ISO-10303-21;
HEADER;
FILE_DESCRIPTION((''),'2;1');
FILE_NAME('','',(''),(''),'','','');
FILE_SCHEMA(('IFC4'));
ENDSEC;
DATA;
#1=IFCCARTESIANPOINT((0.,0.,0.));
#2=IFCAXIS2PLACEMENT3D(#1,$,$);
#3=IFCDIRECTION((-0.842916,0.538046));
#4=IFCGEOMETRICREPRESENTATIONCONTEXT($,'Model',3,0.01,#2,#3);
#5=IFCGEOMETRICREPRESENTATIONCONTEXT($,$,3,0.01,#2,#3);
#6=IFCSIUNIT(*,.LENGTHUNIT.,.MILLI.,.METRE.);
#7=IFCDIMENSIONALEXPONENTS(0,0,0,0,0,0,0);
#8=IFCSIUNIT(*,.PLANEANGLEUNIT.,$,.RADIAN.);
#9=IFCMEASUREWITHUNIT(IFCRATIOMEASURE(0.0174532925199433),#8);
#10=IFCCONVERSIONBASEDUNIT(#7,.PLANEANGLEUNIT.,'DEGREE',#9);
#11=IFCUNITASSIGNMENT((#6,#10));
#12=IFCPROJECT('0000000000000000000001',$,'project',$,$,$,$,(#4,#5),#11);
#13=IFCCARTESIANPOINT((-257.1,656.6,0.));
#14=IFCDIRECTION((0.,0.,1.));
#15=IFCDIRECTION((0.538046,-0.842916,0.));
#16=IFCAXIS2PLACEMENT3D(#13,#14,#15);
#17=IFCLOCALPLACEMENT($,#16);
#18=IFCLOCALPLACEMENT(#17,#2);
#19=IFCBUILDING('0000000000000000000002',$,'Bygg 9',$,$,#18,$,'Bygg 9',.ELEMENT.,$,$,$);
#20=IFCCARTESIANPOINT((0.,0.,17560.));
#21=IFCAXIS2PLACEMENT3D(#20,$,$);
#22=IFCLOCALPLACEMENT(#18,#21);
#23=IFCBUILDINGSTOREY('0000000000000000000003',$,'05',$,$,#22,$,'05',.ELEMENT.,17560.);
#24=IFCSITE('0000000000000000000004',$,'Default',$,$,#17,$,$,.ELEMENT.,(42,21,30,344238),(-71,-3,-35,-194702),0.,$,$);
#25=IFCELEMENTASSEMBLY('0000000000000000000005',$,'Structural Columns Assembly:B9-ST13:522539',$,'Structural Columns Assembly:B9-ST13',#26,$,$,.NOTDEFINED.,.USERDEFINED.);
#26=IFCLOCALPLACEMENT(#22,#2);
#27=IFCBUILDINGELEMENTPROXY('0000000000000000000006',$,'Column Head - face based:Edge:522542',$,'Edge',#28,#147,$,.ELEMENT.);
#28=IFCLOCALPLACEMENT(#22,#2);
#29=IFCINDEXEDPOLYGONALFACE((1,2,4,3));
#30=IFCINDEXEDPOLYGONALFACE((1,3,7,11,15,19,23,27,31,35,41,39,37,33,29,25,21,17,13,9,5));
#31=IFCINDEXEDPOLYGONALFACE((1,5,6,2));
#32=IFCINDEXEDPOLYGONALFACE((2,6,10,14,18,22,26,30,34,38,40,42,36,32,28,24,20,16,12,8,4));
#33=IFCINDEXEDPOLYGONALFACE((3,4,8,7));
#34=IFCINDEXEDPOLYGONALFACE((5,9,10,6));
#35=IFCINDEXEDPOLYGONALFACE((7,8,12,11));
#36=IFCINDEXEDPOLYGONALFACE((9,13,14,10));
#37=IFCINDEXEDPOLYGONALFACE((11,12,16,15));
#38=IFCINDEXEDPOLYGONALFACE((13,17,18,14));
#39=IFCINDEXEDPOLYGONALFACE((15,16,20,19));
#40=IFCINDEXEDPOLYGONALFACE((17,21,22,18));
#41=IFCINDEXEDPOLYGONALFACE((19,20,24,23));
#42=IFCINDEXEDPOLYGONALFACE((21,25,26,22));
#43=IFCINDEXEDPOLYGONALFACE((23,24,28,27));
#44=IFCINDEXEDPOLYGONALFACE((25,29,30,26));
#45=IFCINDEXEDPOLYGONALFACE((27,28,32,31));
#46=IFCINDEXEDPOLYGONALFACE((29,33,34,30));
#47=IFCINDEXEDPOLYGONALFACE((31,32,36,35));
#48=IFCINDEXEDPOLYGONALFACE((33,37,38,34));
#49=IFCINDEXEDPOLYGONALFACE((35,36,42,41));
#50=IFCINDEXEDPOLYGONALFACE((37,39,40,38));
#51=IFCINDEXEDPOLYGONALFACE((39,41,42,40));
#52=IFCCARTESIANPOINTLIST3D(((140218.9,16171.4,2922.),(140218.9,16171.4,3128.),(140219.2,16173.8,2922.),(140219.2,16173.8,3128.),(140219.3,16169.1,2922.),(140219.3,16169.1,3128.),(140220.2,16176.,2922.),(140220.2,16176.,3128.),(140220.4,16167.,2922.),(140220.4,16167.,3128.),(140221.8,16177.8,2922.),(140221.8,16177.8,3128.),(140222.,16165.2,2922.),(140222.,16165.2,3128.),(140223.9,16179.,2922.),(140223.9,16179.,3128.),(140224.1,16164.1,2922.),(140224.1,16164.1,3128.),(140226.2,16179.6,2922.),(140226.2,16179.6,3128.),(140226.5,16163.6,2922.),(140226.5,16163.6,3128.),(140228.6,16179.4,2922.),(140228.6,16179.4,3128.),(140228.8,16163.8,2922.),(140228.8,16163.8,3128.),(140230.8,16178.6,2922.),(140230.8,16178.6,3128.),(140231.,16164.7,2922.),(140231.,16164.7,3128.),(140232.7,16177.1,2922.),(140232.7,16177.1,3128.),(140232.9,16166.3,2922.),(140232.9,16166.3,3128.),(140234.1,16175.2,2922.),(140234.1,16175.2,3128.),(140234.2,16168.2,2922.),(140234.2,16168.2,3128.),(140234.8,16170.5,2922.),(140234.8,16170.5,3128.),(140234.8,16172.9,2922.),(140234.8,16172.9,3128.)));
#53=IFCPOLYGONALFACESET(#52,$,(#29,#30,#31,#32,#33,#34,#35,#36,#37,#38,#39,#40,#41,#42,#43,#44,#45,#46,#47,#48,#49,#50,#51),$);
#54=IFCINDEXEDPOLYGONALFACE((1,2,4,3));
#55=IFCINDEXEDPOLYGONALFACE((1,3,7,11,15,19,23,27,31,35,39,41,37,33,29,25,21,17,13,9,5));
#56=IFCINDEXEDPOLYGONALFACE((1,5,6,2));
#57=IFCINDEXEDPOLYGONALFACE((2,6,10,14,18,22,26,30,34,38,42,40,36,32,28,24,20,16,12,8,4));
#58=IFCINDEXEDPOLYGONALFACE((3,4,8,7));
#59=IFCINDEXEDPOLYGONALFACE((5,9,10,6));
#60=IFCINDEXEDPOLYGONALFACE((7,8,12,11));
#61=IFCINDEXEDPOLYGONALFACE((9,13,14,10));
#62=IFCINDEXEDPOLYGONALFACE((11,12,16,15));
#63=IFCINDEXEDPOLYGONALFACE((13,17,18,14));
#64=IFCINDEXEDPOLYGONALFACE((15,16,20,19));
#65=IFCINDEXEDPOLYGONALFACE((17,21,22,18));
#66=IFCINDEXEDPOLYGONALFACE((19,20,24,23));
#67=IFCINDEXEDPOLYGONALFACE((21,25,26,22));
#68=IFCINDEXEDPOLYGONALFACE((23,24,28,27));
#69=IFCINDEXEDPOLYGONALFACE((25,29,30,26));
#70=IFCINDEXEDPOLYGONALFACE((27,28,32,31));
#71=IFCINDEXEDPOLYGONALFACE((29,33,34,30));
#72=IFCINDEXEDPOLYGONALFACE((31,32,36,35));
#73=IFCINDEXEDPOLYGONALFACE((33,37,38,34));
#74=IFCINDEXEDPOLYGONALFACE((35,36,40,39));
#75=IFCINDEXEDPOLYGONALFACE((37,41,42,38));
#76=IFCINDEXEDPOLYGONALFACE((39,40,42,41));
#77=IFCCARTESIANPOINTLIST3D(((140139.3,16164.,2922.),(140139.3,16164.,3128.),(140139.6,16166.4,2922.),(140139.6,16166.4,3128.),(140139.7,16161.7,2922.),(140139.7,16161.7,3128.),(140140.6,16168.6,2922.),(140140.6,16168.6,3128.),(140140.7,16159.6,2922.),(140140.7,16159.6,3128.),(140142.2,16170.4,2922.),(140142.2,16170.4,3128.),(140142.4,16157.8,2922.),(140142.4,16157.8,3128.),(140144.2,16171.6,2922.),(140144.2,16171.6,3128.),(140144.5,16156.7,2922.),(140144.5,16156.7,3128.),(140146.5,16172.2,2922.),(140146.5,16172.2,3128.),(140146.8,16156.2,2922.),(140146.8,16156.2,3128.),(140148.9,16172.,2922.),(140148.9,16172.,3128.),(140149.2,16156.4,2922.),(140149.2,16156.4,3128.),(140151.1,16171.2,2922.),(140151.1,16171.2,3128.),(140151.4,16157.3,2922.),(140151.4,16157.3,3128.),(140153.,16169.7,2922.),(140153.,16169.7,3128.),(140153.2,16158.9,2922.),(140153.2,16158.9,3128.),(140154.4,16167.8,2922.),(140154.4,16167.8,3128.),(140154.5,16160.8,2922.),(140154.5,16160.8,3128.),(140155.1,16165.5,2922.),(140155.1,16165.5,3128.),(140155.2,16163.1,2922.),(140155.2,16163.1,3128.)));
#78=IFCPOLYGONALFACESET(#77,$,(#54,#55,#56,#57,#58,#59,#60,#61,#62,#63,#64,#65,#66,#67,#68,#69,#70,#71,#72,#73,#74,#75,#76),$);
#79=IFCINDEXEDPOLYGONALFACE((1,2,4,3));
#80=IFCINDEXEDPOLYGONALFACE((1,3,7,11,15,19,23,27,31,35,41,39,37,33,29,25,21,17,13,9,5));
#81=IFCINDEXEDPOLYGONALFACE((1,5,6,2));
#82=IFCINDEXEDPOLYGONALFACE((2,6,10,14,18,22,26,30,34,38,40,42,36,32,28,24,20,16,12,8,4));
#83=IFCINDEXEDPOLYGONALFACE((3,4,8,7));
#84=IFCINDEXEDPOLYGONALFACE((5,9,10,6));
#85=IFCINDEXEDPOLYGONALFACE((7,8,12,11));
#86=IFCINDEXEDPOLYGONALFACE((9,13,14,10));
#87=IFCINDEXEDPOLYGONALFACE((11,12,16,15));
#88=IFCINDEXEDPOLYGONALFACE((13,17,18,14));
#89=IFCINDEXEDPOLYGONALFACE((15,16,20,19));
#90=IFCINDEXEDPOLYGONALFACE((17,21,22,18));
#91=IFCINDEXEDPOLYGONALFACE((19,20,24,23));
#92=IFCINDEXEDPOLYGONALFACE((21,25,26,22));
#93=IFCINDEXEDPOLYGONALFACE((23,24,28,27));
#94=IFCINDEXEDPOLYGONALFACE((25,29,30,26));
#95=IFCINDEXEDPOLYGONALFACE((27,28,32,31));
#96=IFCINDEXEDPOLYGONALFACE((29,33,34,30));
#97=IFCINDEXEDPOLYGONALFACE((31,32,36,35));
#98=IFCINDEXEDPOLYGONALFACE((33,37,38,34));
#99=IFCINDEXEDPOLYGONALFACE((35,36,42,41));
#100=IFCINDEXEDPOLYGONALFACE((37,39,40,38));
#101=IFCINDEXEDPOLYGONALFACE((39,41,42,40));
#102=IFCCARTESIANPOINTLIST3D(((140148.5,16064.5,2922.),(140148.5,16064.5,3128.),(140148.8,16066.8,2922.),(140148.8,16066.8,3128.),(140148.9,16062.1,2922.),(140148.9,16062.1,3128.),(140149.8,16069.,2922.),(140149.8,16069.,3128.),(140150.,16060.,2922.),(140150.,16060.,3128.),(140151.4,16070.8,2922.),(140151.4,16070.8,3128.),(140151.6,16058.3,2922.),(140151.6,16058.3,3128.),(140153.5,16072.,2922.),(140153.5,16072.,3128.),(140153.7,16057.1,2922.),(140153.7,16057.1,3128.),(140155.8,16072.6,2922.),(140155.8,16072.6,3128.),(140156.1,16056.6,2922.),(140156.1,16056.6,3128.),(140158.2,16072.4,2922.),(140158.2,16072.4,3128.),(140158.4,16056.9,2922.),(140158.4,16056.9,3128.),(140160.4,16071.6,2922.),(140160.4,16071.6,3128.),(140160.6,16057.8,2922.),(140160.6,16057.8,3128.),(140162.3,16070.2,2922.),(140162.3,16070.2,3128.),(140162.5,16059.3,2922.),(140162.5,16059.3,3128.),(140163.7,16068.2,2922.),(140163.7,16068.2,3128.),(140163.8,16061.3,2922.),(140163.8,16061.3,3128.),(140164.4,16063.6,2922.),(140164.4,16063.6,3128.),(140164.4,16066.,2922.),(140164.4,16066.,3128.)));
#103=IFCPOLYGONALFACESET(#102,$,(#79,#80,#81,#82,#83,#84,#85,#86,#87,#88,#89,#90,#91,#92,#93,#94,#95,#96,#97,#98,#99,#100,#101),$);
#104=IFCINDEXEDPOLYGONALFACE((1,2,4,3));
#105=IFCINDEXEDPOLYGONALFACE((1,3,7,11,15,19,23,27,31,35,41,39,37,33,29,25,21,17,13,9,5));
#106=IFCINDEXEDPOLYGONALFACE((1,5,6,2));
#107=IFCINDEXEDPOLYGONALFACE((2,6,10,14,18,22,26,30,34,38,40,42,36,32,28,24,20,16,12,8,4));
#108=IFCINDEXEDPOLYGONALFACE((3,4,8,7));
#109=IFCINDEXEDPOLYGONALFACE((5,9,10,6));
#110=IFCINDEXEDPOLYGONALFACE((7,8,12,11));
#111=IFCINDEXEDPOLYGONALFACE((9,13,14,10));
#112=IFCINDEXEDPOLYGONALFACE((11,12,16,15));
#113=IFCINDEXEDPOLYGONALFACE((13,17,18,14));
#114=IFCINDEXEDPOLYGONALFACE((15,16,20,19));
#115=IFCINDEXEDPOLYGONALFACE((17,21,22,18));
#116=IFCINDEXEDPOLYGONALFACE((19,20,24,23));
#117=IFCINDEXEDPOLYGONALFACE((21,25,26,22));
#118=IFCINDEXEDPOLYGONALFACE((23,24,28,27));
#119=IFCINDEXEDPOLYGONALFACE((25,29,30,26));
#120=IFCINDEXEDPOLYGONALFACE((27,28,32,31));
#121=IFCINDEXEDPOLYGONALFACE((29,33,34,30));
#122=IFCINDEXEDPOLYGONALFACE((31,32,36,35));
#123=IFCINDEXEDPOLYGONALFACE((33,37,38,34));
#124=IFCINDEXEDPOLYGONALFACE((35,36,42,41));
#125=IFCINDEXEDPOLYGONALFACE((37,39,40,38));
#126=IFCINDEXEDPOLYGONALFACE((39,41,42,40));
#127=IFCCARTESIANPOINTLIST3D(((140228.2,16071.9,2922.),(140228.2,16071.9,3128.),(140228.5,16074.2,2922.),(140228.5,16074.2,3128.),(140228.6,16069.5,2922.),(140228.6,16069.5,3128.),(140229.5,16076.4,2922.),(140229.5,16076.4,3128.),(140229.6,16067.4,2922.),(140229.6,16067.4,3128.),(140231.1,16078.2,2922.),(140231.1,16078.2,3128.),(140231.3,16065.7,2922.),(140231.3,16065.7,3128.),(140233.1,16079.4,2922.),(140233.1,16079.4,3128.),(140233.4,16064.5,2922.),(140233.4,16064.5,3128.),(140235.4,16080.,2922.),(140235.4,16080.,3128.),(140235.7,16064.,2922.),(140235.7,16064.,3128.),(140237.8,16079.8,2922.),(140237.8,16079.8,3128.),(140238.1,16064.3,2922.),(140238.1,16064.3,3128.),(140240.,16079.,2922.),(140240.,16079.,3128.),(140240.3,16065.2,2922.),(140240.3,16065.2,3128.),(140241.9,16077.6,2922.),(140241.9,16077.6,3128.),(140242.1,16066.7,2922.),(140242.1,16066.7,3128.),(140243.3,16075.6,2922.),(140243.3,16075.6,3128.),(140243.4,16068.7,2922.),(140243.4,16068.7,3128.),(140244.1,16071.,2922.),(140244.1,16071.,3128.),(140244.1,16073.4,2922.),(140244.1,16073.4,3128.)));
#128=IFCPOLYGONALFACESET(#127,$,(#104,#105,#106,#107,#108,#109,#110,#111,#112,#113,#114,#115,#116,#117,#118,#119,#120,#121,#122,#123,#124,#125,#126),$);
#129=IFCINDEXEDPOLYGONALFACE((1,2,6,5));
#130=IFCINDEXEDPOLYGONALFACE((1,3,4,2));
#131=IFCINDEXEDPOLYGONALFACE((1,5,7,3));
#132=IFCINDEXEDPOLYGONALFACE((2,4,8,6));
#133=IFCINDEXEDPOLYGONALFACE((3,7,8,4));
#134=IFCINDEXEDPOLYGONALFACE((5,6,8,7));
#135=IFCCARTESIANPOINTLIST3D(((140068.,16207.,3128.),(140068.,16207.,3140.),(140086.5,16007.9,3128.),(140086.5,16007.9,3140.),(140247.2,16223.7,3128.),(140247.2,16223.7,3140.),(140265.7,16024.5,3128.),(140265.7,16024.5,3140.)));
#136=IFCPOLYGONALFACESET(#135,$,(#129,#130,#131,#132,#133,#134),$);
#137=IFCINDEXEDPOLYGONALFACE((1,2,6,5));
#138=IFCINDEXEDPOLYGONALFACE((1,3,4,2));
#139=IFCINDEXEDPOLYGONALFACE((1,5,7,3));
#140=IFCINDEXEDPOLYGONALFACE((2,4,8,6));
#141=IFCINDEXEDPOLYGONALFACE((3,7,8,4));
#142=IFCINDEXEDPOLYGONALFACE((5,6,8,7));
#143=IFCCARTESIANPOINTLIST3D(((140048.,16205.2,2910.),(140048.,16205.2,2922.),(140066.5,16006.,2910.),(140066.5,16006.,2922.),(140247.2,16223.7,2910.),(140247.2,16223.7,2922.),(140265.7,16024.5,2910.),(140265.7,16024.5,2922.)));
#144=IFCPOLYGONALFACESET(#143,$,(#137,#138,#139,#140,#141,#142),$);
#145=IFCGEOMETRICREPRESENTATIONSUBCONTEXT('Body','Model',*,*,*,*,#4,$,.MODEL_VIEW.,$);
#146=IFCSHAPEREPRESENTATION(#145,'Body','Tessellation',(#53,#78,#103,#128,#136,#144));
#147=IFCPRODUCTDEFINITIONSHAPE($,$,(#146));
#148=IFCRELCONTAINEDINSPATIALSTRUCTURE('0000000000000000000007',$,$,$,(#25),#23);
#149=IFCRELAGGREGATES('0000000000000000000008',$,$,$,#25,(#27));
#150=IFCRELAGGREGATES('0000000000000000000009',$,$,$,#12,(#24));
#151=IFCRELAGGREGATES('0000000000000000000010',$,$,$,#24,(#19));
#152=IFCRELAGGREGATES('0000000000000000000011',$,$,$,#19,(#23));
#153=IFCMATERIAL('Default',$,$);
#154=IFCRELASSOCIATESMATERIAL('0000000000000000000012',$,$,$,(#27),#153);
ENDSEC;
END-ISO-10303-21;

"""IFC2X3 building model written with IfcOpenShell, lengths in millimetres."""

from ifc_helpers import new_model, entity, si_unit, converted_unit, direction, frame, frame_2d, origin, origin_2d_with_axis, place, context, subcontext, project, spatial, rectangle, circle, extrude, source, transform, mapped, material, element, aggregate, save


model = new_model("IFC2X3")

# Units and contexts
model_context = context("Model", 3, precision=0.01, world=origin(), true_north=direction((-0.842916, 0.538046)))
context_of_model = context(None, 3, precision=0.01, world=origin(), true_north=direction((-0.842916, 0.538046)))
body_context = subcontext(model_context, "Body", "Model", "MODEL_VIEW")
ifc_project = project(units=[si_unit("LENGTHUNIT", "METRE", prefix="MILLI"), converted_unit("PLANEANGLEUNIT", "DEGREE", entity("IfcRatioMeasure", 0.0174532925199433), si_unit("PLANEANGLEUNIT", "RADIAN"), dimensions=[0, 0, 0, 0, 0, 0, 0])], contexts=[model_context, context_of_model])

# Site, building, storey
site_placement = place(None, frame((-257.1, 656.6, 0.0), z_axis=(0.0, 0.0, 1.0), x_axis=(0.538046, -0.842916, 0.0)))
site = spatial("IfcSite", under=ifc_project, at=site_placement, Name="Default", CompositionType="ELEMENT", RefLatitude=(42, 21, 30, 344238), RefLongitude=(-71, -3, -35, -194702), RefElevation=0.0)
building_placement = place(site_placement, origin())
building = spatial("IfcBuilding", under=site, at=building_placement, Name="Bygg 9", LongName="Bygg 9", CompositionType="ELEMENT")
storey_placement = place(building_placement, frame((0.0, 0.0, 17560.0)))
storey = spatial("IfcBuildingStorey", under=building, at=storey_placement, Name="05", LongName="05", CompositionType="ELEMENT", Elevation=17560.0)

# Shared definitions
ifc_material_1 = material(Name="Default")

# Element assembly, building element proxy
shared_shape_1 = source(origin(), body_context, "Body", "SweptSolid", [
    extrude(circle(Radius=8.0, at=frame_2d((0.0, 0.0), x_axis=(1.0, 0.0))), frame((50.0, -135.0, 12.0)), (0.0, 0.0, 1.0), 206.0),
    extrude(circle(Radius=8.0, at=frame_2d((0.0, 0.0), x_axis=(1.0, 0.0))), frame((50.0, -55.0, 12.0)), (0.0, 0.0, 1.0), 206.0),
    extrude(circle(Radius=8.0, at=frame_2d((0.0, 0.0), x_axis=(1.0, 0.0))), frame((-50.0, -55.0, 12.0)), (0.0, 0.0, 1.0), 206.0),
    extrude(circle(Radius=8.0, at=frame_2d((0.0, 0.0), x_axis=(1.0, 0.0))), frame((-50.0, -135.0, 12.0)), (0.0, 0.0, 1.0), 206.0),
    extrude(rectangle(XDim=200.0, YDim=180.0, at=origin_2d_with_axis()), frame((0.0, -70.0, 218.0), z_axis=(0.0, 0.0, 1.0), x_axis=(-1.0, 0.0, 0.0)), (0.0, 0.0, 1.0), 12.0),
    extrude(rectangle(XDim=200.0, YDim=200.0, at=origin_2d_with_axis()), frame((0.0, -60.0, 0.0), z_axis=(0.0, 0.0, 1.0), x_axis=(0.0, 1.0, 0.0)), (0.0, 0.0, 1.0), 12.0),
])
assembly_1_placement = place(storey_placement, origin())
assembly_1 = element("IfcElementAssembly", 1, at=assembly_1_placement, inside=storey, Name="Structural Columns Assembly:B9-ST13:522539", ObjectType="Structural Columns Assembly:B9-ST13", AssemblyPlace="NOTDEFINED", PredefinedType="USERDEFINED")
proxy_1_placement = place(assembly_1_placement, frame((140097.1, 16109.3, 2910.0), z_axis=(0.0, 0.0, 1.0), x_axis=(-0.092535, 0.995709, 0.0)))
proxy_1 = element("IfcBuildingElementProxy", 2, at=proxy_1_placement, material=ifc_material_1, Name="Column Head - face based:Edge:522542", ObjectType="Edge", CompositionType="ELEMENT", context=body_context, shape_type="MappedRepresentation", body=[
    mapped(shared_shape_1, transform((0.0, 0.0, 0.0), scale=1.0)),
])
aggregate(assembly_1, [proxy_1])

save(model, "model.ifc")
